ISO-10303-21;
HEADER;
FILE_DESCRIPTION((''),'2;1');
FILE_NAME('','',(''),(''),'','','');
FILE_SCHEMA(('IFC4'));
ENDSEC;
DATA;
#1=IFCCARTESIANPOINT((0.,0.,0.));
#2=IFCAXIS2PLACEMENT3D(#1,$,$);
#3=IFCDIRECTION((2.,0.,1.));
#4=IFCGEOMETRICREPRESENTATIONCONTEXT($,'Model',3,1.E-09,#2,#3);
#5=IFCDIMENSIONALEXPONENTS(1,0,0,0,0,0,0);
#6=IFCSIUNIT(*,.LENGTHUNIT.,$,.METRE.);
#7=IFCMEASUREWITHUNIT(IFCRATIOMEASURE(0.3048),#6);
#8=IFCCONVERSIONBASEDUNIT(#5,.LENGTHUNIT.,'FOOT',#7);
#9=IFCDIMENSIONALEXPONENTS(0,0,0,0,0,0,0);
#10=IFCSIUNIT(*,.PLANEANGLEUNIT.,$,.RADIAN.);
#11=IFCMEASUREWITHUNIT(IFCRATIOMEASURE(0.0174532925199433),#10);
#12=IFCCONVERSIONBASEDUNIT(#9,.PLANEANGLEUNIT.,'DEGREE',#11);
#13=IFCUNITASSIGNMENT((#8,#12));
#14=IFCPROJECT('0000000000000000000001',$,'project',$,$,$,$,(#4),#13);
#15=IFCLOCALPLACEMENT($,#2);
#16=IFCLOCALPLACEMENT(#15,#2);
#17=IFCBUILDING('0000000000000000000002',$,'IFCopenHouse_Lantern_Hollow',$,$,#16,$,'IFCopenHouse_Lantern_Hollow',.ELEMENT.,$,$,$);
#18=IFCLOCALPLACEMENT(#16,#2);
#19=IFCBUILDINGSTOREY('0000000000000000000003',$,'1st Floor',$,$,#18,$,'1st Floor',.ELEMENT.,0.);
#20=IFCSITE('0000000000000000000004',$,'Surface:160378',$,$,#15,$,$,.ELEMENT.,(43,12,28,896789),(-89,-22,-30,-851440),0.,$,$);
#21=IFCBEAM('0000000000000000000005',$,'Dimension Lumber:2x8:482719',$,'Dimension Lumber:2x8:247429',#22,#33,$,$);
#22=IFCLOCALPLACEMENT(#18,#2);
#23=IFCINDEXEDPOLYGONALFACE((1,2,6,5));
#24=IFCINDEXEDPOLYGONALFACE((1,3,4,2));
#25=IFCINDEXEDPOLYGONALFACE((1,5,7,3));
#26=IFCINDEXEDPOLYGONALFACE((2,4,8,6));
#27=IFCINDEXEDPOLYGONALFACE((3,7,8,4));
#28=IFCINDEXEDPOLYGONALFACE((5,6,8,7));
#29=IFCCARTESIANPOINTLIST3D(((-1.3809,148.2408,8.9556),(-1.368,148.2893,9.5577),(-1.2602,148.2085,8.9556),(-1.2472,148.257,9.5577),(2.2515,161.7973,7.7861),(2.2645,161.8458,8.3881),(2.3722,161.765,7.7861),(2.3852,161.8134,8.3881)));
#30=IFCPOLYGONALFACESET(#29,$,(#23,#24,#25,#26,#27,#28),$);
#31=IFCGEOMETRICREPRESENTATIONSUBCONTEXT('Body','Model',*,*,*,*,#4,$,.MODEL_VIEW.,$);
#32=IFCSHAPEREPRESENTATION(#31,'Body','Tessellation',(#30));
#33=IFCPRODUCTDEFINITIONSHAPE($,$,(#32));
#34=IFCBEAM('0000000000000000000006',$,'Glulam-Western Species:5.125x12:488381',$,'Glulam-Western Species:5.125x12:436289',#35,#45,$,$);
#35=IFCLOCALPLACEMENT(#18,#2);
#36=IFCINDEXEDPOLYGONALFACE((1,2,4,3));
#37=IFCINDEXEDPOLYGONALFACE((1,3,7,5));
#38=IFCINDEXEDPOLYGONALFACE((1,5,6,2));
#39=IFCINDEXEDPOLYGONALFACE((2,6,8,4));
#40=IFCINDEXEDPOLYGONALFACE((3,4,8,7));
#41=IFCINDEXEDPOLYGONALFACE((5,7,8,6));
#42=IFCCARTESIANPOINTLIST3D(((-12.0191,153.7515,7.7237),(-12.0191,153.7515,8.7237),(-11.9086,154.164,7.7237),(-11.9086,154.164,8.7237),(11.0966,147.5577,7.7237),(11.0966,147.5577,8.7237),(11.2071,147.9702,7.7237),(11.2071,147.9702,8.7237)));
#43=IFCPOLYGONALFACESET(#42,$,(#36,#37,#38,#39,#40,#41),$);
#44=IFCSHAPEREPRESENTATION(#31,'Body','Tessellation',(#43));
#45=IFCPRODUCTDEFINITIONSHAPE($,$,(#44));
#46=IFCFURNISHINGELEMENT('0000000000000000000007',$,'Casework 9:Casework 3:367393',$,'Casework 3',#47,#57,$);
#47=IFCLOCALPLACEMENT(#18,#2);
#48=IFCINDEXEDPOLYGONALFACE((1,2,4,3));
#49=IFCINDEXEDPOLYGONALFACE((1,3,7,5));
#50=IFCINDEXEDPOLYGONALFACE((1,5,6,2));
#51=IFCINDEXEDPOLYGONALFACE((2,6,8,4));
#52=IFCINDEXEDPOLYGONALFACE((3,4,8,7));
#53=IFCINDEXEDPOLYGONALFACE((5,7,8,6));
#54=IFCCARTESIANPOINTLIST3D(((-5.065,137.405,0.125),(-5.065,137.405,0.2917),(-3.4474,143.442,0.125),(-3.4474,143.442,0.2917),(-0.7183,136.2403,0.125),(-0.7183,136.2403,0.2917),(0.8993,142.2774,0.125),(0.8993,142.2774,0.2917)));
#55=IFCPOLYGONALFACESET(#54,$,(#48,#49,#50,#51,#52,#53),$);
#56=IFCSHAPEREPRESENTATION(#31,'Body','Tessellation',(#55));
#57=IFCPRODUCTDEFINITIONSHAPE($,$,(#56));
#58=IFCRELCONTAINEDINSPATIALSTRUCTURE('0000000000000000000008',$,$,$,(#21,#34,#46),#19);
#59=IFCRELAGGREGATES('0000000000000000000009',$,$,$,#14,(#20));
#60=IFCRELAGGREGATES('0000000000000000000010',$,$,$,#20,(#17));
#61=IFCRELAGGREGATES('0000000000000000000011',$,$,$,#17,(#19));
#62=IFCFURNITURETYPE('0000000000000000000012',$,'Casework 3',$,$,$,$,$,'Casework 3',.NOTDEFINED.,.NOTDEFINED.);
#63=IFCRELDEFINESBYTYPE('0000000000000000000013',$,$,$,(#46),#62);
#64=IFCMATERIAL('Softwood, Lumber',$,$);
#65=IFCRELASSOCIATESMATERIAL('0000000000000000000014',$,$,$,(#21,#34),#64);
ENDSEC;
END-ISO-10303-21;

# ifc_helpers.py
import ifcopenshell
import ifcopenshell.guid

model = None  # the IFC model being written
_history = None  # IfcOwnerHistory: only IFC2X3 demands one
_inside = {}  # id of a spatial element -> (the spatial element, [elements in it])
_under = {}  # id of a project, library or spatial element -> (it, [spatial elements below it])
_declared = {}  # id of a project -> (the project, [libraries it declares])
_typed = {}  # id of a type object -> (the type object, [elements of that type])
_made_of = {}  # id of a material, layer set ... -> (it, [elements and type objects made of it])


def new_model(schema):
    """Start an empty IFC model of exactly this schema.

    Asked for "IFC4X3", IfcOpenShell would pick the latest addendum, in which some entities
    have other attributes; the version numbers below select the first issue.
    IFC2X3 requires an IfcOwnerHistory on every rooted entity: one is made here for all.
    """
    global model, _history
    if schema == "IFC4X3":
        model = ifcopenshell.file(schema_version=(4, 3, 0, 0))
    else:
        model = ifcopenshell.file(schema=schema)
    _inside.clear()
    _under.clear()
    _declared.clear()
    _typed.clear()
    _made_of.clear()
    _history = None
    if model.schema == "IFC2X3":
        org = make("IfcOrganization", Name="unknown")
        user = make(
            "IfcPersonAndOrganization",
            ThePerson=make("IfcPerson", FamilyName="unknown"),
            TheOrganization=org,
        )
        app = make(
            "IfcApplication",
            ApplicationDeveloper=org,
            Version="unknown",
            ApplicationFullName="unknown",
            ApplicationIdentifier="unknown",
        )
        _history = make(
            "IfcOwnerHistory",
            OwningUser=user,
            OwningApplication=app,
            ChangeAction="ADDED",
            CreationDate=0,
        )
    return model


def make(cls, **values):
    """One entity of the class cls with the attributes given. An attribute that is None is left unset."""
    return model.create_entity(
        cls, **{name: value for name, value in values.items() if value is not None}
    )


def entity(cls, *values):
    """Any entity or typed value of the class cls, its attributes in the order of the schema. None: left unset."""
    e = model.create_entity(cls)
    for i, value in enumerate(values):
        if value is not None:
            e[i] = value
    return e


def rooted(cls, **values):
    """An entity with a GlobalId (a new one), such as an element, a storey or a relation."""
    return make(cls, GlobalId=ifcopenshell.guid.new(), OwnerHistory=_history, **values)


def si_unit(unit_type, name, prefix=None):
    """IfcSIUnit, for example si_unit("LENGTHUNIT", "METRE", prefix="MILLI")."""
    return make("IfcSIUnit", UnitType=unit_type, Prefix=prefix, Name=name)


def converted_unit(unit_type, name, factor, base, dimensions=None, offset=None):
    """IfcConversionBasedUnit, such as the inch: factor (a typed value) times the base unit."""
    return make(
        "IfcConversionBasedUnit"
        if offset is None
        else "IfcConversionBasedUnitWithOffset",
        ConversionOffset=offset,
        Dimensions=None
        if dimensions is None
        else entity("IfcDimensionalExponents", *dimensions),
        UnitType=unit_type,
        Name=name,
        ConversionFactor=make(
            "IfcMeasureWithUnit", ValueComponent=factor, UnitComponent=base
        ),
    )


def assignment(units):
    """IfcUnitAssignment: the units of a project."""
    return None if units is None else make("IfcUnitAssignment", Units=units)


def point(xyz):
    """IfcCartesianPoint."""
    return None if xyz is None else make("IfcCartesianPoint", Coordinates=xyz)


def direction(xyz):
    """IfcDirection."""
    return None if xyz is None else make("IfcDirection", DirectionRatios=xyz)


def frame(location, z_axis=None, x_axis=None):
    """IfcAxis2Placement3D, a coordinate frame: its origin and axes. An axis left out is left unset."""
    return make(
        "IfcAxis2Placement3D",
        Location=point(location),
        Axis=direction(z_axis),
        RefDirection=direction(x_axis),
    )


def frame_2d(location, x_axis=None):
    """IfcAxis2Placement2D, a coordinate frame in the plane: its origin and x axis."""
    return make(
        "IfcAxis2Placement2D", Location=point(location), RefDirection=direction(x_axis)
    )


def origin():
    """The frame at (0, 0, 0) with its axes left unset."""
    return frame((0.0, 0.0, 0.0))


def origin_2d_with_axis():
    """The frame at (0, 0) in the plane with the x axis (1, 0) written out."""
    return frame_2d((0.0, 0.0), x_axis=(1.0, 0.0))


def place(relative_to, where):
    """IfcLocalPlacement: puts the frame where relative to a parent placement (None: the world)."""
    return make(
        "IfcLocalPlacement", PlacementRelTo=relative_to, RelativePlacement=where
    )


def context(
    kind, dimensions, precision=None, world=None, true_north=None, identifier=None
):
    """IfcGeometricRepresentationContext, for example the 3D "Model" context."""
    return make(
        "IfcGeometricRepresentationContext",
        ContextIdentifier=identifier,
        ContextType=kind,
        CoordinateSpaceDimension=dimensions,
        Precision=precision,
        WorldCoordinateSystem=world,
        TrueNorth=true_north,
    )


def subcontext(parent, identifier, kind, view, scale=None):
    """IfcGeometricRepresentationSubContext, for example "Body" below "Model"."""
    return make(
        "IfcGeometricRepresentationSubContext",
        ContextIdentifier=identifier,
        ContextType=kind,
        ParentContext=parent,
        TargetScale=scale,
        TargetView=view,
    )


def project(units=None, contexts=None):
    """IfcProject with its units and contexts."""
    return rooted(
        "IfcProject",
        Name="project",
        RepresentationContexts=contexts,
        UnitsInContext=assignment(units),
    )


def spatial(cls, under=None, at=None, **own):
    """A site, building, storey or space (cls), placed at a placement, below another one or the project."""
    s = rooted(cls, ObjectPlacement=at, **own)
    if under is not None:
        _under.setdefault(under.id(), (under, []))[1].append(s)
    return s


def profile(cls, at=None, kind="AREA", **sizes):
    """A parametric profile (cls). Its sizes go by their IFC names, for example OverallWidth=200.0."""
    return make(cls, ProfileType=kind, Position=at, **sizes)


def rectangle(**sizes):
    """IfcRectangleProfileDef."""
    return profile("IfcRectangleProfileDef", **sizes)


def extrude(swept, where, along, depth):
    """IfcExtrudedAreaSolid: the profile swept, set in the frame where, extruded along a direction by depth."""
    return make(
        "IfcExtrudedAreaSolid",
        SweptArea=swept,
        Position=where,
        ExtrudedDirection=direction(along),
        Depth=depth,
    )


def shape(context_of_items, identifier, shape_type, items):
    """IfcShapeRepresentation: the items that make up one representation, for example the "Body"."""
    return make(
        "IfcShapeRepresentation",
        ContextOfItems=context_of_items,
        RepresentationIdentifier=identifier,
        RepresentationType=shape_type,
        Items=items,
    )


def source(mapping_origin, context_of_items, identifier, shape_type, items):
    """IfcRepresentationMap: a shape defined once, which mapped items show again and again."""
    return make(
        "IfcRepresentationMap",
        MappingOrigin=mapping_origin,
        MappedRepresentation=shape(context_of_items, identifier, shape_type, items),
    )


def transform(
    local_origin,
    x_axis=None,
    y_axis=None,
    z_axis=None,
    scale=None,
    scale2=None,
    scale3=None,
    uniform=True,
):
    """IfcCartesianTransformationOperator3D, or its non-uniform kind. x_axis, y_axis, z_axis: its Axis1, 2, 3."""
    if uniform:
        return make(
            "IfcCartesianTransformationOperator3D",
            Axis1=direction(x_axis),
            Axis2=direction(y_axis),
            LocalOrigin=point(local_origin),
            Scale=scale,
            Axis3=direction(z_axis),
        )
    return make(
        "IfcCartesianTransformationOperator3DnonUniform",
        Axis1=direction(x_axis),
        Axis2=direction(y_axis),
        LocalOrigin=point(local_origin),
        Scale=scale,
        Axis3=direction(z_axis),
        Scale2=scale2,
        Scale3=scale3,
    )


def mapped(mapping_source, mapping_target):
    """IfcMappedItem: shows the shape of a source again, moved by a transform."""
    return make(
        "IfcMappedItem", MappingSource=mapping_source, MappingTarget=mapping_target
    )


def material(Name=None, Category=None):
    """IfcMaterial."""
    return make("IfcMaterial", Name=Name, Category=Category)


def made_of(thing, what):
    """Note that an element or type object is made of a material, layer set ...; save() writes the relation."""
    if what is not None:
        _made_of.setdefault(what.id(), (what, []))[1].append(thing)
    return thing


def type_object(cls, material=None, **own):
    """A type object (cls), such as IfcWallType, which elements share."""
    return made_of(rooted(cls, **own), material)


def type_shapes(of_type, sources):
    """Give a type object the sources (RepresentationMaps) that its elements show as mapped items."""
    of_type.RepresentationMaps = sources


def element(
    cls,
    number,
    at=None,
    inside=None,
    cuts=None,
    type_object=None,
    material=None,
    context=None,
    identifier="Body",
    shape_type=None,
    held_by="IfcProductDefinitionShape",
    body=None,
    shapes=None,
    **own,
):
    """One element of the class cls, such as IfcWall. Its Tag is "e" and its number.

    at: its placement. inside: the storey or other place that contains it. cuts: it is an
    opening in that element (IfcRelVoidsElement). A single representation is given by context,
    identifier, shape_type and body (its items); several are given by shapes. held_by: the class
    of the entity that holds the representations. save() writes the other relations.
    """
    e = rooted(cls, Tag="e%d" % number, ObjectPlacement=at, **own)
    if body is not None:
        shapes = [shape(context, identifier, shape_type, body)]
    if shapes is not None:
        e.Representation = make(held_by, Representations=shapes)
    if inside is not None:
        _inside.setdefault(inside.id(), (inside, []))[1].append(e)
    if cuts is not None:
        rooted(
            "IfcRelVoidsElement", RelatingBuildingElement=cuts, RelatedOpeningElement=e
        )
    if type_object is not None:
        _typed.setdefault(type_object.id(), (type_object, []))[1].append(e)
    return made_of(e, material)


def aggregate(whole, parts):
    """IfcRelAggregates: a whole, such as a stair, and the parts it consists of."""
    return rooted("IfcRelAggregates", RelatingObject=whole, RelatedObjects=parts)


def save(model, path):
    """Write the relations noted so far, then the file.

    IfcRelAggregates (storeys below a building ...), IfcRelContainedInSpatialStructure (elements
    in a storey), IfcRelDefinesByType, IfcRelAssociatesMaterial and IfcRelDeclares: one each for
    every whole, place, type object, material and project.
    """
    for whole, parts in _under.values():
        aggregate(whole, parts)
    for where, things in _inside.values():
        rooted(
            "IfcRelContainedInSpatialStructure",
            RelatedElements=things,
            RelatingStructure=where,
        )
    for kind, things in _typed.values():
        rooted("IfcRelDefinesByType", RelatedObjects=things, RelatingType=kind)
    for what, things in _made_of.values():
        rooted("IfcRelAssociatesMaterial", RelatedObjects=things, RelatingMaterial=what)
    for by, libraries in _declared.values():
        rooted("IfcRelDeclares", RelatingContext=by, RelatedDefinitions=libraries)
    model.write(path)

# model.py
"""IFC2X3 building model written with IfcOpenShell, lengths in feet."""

from ifc_helpers import new_model, entity, si_unit, converted_unit, direction, frame, frame_2d, origin, origin_2d_with_axis, place, context, subcontext, project, spatial, rectangle, extrude, source, transform, mapped, material, type_object, type_shapes, element, save


model = new_model("IFC2X3")

# Units and contexts
model_context = context("Model", 3, precision=1e-09, world=origin(), true_north=direction((2.0, 0.0, 1.0)))
body_context = subcontext(model_context, "Body", "Model", "MODEL_VIEW")
ifc_project = project(units=[converted_unit("LENGTHUNIT", "FOOT", entity("IfcRatioMeasure", 0.3048), si_unit("LENGTHUNIT", "METRE"), dimensions=[1, 0, 0, 0, 0, 0, 0]), converted_unit("PLANEANGLEUNIT", "DEGREE", entity("IfcRatioMeasure", 0.0174532925199433), si_unit("PLANEANGLEUNIT", "RADIAN"), dimensions=[0, 0, 0, 0, 0, 0, 0])], contexts=[model_context])

# Site, building, storey
site_placement = place(None, origin())
site = spatial("IfcSite", under=ifc_project, at=site_placement, Name="Surface:160378", CompositionType="ELEMENT", RefLatitude=(43, 12, 28, 896789), RefLongitude=(-89, -22, -30, -851440), RefElevation=0.0)
building_placement = place(site_placement, origin())
building = spatial("IfcBuilding", under=site, at=building_placement, Name="IFCopenHouse_Lantern_Hollow", LongName="IFCopenHouse_Lantern_Hollow", CompositionType="ELEMENT")
storey_placement = place(building_placement, origin())
storey = spatial("IfcBuildingStorey", under=building, at=storey_placement, Name="1st Floor", LongName="1st Floor", CompositionType="ELEMENT", Elevation=0.0)

# Beams
ifc_material = material(Name="Softwood, Lumber")
beam_1_placement = place(storey_placement, frame((-1.4867, 147.6047, 1.2536), z_axis=(0.021494, 0.080216, 0.996546), x_axis=(0.257925, 0.962589, -0.083045)))
element("IfcBeam", 1, at=beam_1_placement, inside=storey, material=ifc_material, Name="Dimension Lumber:2x8:482719", ObjectType="Dimension Lumber:2x8:247429", context=body_context, shape_type="SweptSolid", body=[
    extrude(rectangle(XDim=0.6042, YDim=0.125, at=frame_2d((0.0, 0.0), x_axis=(1.0, 0.0))), frame((0.0, 0.0, 8.0308), z_axis=(1.0, 0.0, 0.0), x_axis=(0.0, 0.0, -1.0)), (0.0, 0.0, 1.0), 14.0833),
])
beam_2_placement = place(storey_placement, frame((-11.9638, 153.9577, 8.7237), z_axis=(0.0, 0.0, 1.0), x_axis=(0.965926, -0.258819, 0.0)))
element("IfcBeam", 2, at=beam_2_placement, inside=storey, material=ifc_material, Name="Glulam-Western Species:5.125x12:488381", ObjectType="Glulam-Western Species:5.125x12:436289", context=body_context, shape_type="SweptSolid", body=[
    extrude(rectangle(XDim=1.0, YDim=0.4271, at=origin_2d_with_axis()), frame((0.0, 0.0, -0.5), z_axis=(1.0, 0.0, 0.0), x_axis=(0.0, 0.0, -1.0)), (0.0, 0.0, 1.0), 23.9311),
])

# Furnishing element
furniture_type = type_object("IfcFurnitureType", Name="Casework 3", ElementType="Casework 3", AssemblyPlace="NOTDEFINED")
shared_shape = source(origin(), body_context, "Body", "SweptSolid", [
    extrude(rectangle(XDim=4.5, YDim=6.25, at=frame_2d((0.0, 0.0), x_axis=(1.0, 0.0))), frame((2.9821, 3.6009, 0.0), z_axis=(0.0, 0.0, 1.0), x_axis=(0.965926, -0.258819, 0.0)), (0.0, 0.0, 1.0), 0.1667),
])
type_shapes(furniture_type, [shared_shape])
furnishing_placement = place(storey_placement, frame((-5.065, 136.2403, 0.125)))
element("IfcFurnishingElement", 3, at=furnishing_placement, inside=storey, type_object=furniture_type, Name="Casework 9:Casework 3:367393", ObjectType="Casework 3", context=body_context, shape_type="MappedRepresentation", body=[
    mapped(shared_shape, transform((0.0, 0.0, 0.0), scale=1.0)),
])

save(model, "model.ifc")
